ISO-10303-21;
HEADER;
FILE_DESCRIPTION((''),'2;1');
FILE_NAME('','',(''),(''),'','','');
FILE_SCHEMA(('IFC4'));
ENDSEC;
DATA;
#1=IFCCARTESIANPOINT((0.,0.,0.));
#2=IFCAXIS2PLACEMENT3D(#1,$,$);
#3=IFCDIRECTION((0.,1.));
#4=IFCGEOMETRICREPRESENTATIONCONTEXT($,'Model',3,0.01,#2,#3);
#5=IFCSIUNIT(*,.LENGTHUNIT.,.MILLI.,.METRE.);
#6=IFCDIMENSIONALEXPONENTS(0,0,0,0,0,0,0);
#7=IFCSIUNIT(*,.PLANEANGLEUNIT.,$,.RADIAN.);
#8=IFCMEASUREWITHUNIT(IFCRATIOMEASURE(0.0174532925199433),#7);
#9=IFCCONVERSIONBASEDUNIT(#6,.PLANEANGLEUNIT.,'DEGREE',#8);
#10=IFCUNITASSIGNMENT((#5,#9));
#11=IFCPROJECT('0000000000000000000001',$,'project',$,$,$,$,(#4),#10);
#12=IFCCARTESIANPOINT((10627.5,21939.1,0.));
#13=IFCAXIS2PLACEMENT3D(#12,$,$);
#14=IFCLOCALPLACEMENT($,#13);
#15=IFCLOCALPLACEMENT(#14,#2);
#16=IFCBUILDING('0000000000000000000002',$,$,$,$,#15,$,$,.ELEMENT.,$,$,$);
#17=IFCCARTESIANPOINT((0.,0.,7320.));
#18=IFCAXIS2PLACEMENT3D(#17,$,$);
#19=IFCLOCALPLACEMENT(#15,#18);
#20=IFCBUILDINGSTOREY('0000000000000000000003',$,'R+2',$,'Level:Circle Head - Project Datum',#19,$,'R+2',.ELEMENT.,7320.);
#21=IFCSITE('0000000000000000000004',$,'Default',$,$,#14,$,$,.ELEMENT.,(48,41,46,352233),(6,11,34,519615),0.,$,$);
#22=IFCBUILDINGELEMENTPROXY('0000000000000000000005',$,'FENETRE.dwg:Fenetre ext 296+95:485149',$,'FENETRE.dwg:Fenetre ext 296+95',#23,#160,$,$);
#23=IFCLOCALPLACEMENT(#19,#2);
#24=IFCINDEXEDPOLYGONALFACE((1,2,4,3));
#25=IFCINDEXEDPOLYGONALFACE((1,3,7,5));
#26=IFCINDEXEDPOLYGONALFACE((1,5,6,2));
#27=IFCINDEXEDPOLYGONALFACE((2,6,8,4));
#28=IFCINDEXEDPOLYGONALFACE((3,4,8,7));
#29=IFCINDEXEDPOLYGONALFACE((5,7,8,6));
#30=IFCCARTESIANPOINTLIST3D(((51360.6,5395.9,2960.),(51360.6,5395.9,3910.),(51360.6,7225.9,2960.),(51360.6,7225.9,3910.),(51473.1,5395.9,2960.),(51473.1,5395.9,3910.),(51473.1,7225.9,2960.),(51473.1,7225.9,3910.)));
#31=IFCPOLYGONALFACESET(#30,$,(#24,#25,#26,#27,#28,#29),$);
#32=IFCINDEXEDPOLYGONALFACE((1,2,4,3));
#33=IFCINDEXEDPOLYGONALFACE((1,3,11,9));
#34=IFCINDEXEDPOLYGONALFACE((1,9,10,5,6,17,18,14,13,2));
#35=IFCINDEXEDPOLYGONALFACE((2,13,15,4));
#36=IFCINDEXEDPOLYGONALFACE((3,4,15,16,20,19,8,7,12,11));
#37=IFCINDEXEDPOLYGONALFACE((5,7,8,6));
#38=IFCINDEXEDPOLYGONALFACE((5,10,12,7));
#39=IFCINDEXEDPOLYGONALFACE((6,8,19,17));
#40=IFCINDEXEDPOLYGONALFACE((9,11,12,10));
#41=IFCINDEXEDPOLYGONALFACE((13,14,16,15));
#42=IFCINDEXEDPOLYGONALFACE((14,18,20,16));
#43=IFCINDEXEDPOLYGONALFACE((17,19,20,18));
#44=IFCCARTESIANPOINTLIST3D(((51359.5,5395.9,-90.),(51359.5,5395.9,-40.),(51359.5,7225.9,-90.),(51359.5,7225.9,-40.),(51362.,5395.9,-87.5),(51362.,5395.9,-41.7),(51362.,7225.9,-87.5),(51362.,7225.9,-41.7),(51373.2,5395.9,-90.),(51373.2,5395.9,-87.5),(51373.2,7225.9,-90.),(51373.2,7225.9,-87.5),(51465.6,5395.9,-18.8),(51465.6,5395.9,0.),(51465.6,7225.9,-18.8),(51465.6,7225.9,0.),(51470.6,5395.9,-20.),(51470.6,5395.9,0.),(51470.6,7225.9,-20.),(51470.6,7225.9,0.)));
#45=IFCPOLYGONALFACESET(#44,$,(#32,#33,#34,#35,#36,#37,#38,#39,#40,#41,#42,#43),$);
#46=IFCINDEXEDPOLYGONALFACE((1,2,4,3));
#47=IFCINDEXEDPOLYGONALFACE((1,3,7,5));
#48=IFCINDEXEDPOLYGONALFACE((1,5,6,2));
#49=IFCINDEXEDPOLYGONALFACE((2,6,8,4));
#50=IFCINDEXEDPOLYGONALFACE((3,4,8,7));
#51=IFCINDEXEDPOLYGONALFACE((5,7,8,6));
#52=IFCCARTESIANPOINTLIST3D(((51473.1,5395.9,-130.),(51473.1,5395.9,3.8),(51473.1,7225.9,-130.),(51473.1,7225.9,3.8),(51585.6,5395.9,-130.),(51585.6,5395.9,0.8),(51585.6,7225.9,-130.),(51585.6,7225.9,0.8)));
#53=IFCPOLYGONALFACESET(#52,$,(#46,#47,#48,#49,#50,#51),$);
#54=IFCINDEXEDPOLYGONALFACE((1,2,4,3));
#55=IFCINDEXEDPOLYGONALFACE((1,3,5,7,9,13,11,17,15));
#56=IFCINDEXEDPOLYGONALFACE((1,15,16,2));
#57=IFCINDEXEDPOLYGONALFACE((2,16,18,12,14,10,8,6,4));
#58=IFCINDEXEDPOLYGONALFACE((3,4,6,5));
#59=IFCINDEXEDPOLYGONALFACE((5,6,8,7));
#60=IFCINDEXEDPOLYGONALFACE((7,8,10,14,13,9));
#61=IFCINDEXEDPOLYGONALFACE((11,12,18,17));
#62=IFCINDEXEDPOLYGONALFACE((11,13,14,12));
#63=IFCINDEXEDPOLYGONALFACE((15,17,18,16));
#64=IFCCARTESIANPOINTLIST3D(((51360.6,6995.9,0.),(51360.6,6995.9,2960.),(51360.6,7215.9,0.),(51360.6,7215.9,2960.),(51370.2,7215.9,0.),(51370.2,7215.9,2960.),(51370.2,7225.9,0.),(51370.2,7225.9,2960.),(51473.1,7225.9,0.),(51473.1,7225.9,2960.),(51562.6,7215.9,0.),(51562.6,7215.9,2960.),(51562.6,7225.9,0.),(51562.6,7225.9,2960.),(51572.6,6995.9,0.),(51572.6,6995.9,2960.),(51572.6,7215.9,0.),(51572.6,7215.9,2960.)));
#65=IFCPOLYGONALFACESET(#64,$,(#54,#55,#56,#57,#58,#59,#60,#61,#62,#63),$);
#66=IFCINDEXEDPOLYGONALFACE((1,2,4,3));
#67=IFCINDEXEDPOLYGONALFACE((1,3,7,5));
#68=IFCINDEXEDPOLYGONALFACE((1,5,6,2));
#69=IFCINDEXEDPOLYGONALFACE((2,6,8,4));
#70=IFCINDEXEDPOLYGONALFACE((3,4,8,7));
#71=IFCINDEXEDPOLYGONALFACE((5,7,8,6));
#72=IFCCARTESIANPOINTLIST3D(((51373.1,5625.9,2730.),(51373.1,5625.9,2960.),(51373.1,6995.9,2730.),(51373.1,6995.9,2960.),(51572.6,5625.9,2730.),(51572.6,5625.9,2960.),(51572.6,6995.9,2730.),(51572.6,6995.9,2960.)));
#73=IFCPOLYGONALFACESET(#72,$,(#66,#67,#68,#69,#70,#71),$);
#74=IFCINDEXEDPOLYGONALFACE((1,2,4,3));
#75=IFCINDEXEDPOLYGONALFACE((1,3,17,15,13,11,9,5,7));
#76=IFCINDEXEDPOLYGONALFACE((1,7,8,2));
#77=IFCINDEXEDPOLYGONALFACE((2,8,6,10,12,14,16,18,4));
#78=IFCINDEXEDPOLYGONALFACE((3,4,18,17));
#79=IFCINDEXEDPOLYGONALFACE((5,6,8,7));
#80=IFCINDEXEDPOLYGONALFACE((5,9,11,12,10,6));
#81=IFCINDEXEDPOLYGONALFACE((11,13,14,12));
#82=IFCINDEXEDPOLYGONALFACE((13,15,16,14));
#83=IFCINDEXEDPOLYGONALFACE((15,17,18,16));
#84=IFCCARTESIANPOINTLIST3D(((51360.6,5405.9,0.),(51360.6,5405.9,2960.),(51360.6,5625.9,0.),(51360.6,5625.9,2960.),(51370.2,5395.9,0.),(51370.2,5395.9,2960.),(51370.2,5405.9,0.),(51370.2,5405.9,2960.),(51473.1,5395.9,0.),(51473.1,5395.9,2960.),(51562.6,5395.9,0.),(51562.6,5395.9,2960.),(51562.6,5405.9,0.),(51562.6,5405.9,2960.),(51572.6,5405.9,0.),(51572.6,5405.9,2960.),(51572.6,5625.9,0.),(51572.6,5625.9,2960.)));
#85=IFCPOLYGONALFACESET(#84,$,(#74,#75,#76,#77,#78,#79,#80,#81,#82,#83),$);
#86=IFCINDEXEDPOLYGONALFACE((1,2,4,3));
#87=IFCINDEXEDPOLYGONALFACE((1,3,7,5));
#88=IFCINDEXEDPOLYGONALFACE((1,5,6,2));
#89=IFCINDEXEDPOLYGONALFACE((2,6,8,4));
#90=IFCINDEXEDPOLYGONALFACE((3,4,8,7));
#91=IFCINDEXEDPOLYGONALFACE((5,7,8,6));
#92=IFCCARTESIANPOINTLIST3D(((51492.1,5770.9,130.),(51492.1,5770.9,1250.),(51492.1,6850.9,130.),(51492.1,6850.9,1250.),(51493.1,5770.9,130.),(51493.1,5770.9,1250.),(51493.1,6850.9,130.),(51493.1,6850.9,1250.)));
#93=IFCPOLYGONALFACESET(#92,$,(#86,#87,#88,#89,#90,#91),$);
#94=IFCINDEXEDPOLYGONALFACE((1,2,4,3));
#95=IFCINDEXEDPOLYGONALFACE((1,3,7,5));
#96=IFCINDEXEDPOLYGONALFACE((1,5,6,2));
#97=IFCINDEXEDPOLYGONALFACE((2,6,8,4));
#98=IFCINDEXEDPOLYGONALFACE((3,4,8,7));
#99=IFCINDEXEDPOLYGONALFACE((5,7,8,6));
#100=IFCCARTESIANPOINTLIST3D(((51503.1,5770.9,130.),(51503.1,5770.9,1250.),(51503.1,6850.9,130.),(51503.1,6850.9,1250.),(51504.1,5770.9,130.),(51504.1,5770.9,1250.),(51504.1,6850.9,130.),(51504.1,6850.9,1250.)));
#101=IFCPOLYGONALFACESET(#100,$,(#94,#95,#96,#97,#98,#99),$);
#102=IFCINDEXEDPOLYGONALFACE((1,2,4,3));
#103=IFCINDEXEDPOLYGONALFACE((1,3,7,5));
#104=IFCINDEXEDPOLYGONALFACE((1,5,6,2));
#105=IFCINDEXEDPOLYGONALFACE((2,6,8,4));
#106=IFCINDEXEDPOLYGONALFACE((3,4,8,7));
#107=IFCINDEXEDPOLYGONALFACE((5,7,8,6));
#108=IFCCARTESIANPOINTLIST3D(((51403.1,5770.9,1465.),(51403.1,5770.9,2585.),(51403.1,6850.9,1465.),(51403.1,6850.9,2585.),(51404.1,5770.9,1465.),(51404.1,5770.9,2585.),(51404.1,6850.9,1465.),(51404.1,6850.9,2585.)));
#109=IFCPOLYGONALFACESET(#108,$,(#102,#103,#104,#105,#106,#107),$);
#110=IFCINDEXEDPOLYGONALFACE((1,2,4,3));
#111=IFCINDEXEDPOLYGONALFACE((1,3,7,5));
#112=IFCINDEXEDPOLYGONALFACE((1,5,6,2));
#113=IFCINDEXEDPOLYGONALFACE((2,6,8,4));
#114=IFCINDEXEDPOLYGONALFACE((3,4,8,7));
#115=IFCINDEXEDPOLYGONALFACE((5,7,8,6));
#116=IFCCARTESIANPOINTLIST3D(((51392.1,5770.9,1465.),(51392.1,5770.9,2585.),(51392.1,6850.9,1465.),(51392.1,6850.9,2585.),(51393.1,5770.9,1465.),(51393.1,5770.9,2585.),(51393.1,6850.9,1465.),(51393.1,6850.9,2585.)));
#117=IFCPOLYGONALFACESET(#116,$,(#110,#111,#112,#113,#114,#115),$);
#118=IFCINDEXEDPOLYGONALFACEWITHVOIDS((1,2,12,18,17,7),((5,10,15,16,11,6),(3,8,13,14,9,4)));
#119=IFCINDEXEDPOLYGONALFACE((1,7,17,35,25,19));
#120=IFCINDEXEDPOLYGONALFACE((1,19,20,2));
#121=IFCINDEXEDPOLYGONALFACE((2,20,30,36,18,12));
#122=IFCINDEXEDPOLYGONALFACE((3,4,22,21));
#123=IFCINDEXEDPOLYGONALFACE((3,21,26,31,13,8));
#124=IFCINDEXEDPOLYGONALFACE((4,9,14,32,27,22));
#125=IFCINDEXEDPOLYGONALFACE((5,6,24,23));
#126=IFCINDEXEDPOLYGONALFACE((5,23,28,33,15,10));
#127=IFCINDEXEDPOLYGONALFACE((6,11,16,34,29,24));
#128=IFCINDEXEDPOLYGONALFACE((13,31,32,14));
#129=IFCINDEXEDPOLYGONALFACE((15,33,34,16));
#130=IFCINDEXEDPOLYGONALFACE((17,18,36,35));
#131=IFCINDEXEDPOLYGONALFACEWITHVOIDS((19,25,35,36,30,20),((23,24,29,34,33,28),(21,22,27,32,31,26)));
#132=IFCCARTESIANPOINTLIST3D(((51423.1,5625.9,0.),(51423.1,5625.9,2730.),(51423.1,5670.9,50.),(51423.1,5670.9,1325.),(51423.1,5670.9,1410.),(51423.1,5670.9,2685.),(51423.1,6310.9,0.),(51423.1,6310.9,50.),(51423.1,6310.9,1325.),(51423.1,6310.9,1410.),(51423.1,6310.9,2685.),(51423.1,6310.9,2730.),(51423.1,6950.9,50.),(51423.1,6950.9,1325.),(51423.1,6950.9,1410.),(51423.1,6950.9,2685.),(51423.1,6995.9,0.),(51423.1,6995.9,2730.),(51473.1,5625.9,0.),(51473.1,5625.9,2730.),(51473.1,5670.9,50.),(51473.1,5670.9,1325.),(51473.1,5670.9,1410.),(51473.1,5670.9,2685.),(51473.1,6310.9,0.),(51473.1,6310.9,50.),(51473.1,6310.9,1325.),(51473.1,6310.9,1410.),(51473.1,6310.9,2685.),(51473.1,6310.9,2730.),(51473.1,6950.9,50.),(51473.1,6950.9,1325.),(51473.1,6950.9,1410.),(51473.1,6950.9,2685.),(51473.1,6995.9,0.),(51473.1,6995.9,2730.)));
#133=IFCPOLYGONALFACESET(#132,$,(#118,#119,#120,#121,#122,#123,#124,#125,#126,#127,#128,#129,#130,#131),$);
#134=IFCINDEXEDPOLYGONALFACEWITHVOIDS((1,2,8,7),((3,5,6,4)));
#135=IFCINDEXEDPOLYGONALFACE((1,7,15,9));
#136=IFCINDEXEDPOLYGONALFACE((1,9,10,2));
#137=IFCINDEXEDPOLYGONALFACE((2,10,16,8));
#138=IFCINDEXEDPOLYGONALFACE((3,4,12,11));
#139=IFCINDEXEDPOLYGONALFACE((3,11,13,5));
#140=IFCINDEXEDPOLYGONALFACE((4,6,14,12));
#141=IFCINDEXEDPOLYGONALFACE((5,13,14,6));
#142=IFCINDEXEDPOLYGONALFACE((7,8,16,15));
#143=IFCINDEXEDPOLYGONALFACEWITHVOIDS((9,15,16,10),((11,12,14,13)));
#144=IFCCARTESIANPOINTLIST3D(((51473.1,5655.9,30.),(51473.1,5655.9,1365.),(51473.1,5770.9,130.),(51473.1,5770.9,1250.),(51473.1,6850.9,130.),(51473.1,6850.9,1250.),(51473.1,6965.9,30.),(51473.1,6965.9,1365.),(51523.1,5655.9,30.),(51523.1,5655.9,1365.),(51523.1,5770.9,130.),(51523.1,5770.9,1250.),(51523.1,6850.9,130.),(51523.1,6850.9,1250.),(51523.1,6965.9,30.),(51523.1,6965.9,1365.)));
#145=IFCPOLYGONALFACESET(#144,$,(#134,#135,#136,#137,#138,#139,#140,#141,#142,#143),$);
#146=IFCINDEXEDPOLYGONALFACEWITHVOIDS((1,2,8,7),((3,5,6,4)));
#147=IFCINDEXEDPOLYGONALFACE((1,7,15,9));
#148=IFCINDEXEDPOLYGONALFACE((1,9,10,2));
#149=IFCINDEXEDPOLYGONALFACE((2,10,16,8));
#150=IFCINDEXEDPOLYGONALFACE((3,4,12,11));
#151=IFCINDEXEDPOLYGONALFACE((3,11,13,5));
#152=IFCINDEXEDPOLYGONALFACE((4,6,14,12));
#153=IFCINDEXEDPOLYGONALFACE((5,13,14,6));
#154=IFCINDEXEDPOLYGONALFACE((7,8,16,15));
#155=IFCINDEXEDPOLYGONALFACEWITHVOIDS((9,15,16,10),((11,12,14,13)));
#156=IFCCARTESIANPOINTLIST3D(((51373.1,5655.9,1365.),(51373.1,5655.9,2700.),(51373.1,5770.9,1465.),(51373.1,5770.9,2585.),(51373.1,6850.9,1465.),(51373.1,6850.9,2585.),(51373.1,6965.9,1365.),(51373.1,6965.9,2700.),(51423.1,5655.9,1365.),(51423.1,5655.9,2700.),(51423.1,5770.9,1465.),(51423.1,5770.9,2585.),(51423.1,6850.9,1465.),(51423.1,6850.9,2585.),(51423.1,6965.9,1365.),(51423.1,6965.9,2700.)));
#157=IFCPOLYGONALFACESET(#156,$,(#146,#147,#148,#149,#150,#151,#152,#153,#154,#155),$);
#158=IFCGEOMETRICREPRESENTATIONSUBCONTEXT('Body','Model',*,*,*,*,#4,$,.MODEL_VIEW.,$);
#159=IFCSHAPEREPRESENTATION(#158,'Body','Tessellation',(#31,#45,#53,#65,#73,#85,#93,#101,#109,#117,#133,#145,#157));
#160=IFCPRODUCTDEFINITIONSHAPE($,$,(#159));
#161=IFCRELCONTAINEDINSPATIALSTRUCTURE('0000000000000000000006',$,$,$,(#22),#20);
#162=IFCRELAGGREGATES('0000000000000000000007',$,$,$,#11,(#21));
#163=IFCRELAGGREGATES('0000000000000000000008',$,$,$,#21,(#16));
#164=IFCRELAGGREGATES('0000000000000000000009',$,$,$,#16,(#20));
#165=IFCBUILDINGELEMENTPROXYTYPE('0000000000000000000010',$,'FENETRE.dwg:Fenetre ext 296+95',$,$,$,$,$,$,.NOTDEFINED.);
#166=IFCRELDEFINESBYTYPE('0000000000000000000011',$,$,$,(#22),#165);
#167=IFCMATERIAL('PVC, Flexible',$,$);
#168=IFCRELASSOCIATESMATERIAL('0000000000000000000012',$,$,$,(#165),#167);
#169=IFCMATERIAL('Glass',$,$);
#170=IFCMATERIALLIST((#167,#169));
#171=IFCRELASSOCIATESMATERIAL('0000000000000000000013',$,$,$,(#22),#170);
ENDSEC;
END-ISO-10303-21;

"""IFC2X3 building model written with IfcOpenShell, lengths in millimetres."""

from ifc_helpers import new_model, entity, si_unit, converted_unit, direction, frame, frame_2d, origin, origin_2d_with_axis, place, context, subcontext, project, spatial, polyline, rectangle, outline, extrude, source, transform, mapped, material, material_list, type_object, type_shapes, element, save


model = new_model("IFC2X3")

# Units and contexts
model_context = context("Model", 3, precision=0.01, world=origin(), true_north=direction((0.0, 1.0)))
body_context = subcontext(model_context, "Body", "Model", "MODEL_VIEW")
ifc_project = project(units=[si_unit("LENGTHUNIT", "METRE", prefix="MILLI"), converted_unit("PLANEANGLEUNIT", "DEGREE", entity("IfcRatioMeasure", 0.0174532925199433), si_unit("PLANEANGLEUNIT", "RADIAN"), dimensions=[0, 0, 0, 0, 0, 0, 0])], contexts=[model_context])

# Site, building, storey
site_placement = place(None, frame((10627.5, 21939.1, 0.0)))
site = spatial("IfcSite", under=ifc_project, at=site_placement, Name="Default", CompositionType="ELEMENT", RefLatitude=(48, 41, 46, 352233), RefLongitude=(6, 11, 34, 519615), RefElevation=0.0)
building_placement = place(site_placement, origin())
building = spatial("IfcBuilding", under=site, at=building_placement, CompositionType="ELEMENT")
storey_placement = place(building_placement, frame((0.0, 0.0, 7320.0)))
storey = spatial("IfcBuildingStorey", under=building, at=storey_placement, Name="R+2", ObjectType="Level:Circle Head - Project Datum", LongName="R+2", CompositionType="ELEMENT", Elevation=7320.0)

# Building element proxy
ifc_material_1 = material(Name="PVC, Flexible")
ifc_material_2 = material(Name="Glass")
building_element_proxy_type_1 = type_object("IfcBuildingElementProxyType", Name="FENETRE.dwg:Fenetre ext 296+95", PredefinedType="NOTDEFINED", material=ifc_material_1)
shared_shape_1 = source(origin(), body_context, "Body", "SweptSolid", [
    extrude(rectangle(XDim=1830.0, YDim=112.5, at=origin_2d_with_axis()), frame((-10.4, 56.3, 2960.0), z_axis=(0.0, 0.0, 1.0), x_axis=(-1.0, 0.0, 0.0)), (0.0, 0.0, 1.0), 950.0),
    extrude(outline(polyline([(-68.6, -14.4), (-72.5, -34.0), (-67.6, -35.0), (-63.9, -16.6), (44.3, -16.6), (54.1, 32.5), (40.6, 35.2), (40.1, 32.7), (51.2, 30.5), (42.2, -14.4), (-68.6, -14.4)])), frame((-925.4, 66.9, -47.5), z_axis=(-1.0, 0.0, 0.0), x_axis=(0.0, 0.980599, -0.196027)), (0.0, 0.0, -1.0), 1830.0),
    extrude(outline(polyline([(-64.7, -56.3), (66.2, -56.3), (66.2, 56.3), (-67.7, 56.3), (-64.7, -56.3)])), frame((-925.4, -56.3, -63.8), z_axis=(1.0, 0.0, 0.0), x_axis=(0.0, 0.0, -1.0)), (0.0, 0.0, 1.0), 1830.0),
    extrude(outline(polyline([(-55.6, 97.0), (-55.6, -5.9), (-55.6, -95.4), (-45.6, -95.4), (-45.6, -105.4), (174.4, -105.4), (174.4, 106.6), (-45.6, 106.6), (-45.6, 97.0), (-55.6, 97.0)])), frame((849.0, 5.9, 0.0), z_axis=(0.0, 0.0, -1.0), x_axis=(-1.0, 0.0, 0.0)), (0.0, 0.0, -1.0), 2960.0),
    extrude(rectangle(XDim=199.5, YDim=1370.0, at=origin_2d_with_axis()), frame((-10.4, 0.3, 2730.0), z_axis=(0.0, 0.0, 1.0), x_axis=(0.0, 1.0, 0.0)), (0.0, 0.0, 1.0), 230.0),
    extrude(outline(polyline([(-97.0, -55.6), (5.9, -55.6), (95.4, -55.6), (95.4, -45.6), (105.4, -45.6), (105.4, 174.4), (-106.6, 174.4), (-106.6, -45.6), (-97.0, -45.6), (-97.0, -55.6)])), frame((-869.9, 5.9, 0.0), z_axis=(0.0, 0.0, 1.0), x_axis=(0.0, -1.0, 0.0)), (0.0, 0.0, 1.0), 2960.0),
    extrude(rectangle(XDim=1.0, YDim=1080.0, at=origin_2d_with_axis()), frame((-10.4, -19.5, 130.0), z_axis=(0.0, 0.0, 1.0), x_axis=(0.0, 1.0, 0.0)), (0.0, 0.0, 1.0), 1120.0),
    extrude(rectangle(XDim=1.0, YDim=1080.0, at=frame_2d((0.0, 0.0), x_axis=(1.0, 0.0))), frame((-10.4, -30.5, 130.0), z_axis=(0.0, 0.0, 1.0), x_axis=(0.0, 1.0, 0.0)), (0.0, 0.0, 1.0), 1120.0),
    extrude(rectangle(XDim=1.0, YDim=1080.0, at=frame_2d((0.0, 0.0), x_axis=(1.0, 0.0))), frame((-10.4, 69.5, 1465.0), z_axis=(0.0, 0.0, 1.0), x_axis=(0.0, 1.0, 0.0)), (0.0, 0.0, 1.0), 1120.0),
    extrude(rectangle(XDim=1.0, YDim=1080.0, at=frame_2d((0.0, 0.0), x_axis=(1.0, 0.0))), frame((-10.4, 80.5, 1465.0), z_axis=(0.0, 0.0, 1.0), x_axis=(0.0, 1.0, 0.0)), (0.0, 0.0, 1.0), 1120.0),
    extrude(outline(polyline([(-685.0, -1365.0), (0.0, -1365.0), (685.0, -1365.0), (685.0, 1365.0), (0.0, 1365.0), (-685.0, 1365.0), (-685.0, -1365.0)]), holes=[polyline([(-640.0, -1320.0), (-640.0, -45.0), (0.0, -45.0), (640.0, -45.0), (640.0, -1320.0), (0.0, -1320.0), (-640.0, -1320.0)]), polyline([(-640.0, 40.0), (-640.0, 1315.0), (0.0, 1315.0), (640.0, 1315.0), (640.0, 40.0), (0.0, 40.0), (-640.0, 40.0)])]), frame((-10.4, 0.0, 1365.0), z_axis=(0.0, 1.0, 0.0), x_axis=(1.0, 0.0, 0.0)), (0.0, 0.0, 1.0), 50.0),
    extrude(outline(polyline([(-655.0, -667.5), (655.0, -667.5), (655.0, 667.5), (-655.0, 667.5), (-655.0, -667.5)]), holes=[polyline([(-540.0, 552.5), (540.0, 552.5), (540.0, -567.5), (-540.0, -567.5), (-540.0, 552.5)])]), frame((-10.4, -50.0, 697.5), z_axis=(0.0, 1.0, 0.0), x_axis=(-1.0, 0.0, 0.0)), (0.0, 0.0, 1.0), 50.0),
    extrude(outline(polyline([(-655.0, -667.5), (655.0, -667.5), (655.0, 667.5), (-655.0, 667.5), (-655.0, -667.5)]), holes=[polyline([(-540.0, 552.5), (540.0, 552.5), (540.0, -567.5), (-540.0, -567.5), (-540.0, 552.5)])]), frame((-10.4, 50.0, 2032.5), z_axis=(0.0, 1.0, 0.0), x_axis=(-1.0, 0.0, 0.0)), (0.0, 0.0, 1.0), 50.0),
])
type_shapes(building_element_proxy_type_1, [shared_shape_1])
ifc_material_list_1 = material_list([ifc_material_1, ifc_material_2])
proxy_1_placement = place(storey_placement, frame((51473.1, 6321.3, 0.0), z_axis=(0.0, 0.0, 1.0), x_axis=(0.0, 1.0, 0.0)))
element("IfcBuildingElementProxy", 1, at=proxy_1_placement, inside=storey, type_object=building_element_proxy_type_1, material=ifc_material_list_1, Name="FENETRE.dwg:Fenetre ext 296+95:485149", ObjectType="FENETRE.dwg:Fenetre ext 296+95", context=body_context, shape_type="MappedRepresentation", body=[
    mapped(shared_shape_1, transform((0.0, 0.0, 0.0), scale=1.0)),
])

save(model, "model.ifc")
